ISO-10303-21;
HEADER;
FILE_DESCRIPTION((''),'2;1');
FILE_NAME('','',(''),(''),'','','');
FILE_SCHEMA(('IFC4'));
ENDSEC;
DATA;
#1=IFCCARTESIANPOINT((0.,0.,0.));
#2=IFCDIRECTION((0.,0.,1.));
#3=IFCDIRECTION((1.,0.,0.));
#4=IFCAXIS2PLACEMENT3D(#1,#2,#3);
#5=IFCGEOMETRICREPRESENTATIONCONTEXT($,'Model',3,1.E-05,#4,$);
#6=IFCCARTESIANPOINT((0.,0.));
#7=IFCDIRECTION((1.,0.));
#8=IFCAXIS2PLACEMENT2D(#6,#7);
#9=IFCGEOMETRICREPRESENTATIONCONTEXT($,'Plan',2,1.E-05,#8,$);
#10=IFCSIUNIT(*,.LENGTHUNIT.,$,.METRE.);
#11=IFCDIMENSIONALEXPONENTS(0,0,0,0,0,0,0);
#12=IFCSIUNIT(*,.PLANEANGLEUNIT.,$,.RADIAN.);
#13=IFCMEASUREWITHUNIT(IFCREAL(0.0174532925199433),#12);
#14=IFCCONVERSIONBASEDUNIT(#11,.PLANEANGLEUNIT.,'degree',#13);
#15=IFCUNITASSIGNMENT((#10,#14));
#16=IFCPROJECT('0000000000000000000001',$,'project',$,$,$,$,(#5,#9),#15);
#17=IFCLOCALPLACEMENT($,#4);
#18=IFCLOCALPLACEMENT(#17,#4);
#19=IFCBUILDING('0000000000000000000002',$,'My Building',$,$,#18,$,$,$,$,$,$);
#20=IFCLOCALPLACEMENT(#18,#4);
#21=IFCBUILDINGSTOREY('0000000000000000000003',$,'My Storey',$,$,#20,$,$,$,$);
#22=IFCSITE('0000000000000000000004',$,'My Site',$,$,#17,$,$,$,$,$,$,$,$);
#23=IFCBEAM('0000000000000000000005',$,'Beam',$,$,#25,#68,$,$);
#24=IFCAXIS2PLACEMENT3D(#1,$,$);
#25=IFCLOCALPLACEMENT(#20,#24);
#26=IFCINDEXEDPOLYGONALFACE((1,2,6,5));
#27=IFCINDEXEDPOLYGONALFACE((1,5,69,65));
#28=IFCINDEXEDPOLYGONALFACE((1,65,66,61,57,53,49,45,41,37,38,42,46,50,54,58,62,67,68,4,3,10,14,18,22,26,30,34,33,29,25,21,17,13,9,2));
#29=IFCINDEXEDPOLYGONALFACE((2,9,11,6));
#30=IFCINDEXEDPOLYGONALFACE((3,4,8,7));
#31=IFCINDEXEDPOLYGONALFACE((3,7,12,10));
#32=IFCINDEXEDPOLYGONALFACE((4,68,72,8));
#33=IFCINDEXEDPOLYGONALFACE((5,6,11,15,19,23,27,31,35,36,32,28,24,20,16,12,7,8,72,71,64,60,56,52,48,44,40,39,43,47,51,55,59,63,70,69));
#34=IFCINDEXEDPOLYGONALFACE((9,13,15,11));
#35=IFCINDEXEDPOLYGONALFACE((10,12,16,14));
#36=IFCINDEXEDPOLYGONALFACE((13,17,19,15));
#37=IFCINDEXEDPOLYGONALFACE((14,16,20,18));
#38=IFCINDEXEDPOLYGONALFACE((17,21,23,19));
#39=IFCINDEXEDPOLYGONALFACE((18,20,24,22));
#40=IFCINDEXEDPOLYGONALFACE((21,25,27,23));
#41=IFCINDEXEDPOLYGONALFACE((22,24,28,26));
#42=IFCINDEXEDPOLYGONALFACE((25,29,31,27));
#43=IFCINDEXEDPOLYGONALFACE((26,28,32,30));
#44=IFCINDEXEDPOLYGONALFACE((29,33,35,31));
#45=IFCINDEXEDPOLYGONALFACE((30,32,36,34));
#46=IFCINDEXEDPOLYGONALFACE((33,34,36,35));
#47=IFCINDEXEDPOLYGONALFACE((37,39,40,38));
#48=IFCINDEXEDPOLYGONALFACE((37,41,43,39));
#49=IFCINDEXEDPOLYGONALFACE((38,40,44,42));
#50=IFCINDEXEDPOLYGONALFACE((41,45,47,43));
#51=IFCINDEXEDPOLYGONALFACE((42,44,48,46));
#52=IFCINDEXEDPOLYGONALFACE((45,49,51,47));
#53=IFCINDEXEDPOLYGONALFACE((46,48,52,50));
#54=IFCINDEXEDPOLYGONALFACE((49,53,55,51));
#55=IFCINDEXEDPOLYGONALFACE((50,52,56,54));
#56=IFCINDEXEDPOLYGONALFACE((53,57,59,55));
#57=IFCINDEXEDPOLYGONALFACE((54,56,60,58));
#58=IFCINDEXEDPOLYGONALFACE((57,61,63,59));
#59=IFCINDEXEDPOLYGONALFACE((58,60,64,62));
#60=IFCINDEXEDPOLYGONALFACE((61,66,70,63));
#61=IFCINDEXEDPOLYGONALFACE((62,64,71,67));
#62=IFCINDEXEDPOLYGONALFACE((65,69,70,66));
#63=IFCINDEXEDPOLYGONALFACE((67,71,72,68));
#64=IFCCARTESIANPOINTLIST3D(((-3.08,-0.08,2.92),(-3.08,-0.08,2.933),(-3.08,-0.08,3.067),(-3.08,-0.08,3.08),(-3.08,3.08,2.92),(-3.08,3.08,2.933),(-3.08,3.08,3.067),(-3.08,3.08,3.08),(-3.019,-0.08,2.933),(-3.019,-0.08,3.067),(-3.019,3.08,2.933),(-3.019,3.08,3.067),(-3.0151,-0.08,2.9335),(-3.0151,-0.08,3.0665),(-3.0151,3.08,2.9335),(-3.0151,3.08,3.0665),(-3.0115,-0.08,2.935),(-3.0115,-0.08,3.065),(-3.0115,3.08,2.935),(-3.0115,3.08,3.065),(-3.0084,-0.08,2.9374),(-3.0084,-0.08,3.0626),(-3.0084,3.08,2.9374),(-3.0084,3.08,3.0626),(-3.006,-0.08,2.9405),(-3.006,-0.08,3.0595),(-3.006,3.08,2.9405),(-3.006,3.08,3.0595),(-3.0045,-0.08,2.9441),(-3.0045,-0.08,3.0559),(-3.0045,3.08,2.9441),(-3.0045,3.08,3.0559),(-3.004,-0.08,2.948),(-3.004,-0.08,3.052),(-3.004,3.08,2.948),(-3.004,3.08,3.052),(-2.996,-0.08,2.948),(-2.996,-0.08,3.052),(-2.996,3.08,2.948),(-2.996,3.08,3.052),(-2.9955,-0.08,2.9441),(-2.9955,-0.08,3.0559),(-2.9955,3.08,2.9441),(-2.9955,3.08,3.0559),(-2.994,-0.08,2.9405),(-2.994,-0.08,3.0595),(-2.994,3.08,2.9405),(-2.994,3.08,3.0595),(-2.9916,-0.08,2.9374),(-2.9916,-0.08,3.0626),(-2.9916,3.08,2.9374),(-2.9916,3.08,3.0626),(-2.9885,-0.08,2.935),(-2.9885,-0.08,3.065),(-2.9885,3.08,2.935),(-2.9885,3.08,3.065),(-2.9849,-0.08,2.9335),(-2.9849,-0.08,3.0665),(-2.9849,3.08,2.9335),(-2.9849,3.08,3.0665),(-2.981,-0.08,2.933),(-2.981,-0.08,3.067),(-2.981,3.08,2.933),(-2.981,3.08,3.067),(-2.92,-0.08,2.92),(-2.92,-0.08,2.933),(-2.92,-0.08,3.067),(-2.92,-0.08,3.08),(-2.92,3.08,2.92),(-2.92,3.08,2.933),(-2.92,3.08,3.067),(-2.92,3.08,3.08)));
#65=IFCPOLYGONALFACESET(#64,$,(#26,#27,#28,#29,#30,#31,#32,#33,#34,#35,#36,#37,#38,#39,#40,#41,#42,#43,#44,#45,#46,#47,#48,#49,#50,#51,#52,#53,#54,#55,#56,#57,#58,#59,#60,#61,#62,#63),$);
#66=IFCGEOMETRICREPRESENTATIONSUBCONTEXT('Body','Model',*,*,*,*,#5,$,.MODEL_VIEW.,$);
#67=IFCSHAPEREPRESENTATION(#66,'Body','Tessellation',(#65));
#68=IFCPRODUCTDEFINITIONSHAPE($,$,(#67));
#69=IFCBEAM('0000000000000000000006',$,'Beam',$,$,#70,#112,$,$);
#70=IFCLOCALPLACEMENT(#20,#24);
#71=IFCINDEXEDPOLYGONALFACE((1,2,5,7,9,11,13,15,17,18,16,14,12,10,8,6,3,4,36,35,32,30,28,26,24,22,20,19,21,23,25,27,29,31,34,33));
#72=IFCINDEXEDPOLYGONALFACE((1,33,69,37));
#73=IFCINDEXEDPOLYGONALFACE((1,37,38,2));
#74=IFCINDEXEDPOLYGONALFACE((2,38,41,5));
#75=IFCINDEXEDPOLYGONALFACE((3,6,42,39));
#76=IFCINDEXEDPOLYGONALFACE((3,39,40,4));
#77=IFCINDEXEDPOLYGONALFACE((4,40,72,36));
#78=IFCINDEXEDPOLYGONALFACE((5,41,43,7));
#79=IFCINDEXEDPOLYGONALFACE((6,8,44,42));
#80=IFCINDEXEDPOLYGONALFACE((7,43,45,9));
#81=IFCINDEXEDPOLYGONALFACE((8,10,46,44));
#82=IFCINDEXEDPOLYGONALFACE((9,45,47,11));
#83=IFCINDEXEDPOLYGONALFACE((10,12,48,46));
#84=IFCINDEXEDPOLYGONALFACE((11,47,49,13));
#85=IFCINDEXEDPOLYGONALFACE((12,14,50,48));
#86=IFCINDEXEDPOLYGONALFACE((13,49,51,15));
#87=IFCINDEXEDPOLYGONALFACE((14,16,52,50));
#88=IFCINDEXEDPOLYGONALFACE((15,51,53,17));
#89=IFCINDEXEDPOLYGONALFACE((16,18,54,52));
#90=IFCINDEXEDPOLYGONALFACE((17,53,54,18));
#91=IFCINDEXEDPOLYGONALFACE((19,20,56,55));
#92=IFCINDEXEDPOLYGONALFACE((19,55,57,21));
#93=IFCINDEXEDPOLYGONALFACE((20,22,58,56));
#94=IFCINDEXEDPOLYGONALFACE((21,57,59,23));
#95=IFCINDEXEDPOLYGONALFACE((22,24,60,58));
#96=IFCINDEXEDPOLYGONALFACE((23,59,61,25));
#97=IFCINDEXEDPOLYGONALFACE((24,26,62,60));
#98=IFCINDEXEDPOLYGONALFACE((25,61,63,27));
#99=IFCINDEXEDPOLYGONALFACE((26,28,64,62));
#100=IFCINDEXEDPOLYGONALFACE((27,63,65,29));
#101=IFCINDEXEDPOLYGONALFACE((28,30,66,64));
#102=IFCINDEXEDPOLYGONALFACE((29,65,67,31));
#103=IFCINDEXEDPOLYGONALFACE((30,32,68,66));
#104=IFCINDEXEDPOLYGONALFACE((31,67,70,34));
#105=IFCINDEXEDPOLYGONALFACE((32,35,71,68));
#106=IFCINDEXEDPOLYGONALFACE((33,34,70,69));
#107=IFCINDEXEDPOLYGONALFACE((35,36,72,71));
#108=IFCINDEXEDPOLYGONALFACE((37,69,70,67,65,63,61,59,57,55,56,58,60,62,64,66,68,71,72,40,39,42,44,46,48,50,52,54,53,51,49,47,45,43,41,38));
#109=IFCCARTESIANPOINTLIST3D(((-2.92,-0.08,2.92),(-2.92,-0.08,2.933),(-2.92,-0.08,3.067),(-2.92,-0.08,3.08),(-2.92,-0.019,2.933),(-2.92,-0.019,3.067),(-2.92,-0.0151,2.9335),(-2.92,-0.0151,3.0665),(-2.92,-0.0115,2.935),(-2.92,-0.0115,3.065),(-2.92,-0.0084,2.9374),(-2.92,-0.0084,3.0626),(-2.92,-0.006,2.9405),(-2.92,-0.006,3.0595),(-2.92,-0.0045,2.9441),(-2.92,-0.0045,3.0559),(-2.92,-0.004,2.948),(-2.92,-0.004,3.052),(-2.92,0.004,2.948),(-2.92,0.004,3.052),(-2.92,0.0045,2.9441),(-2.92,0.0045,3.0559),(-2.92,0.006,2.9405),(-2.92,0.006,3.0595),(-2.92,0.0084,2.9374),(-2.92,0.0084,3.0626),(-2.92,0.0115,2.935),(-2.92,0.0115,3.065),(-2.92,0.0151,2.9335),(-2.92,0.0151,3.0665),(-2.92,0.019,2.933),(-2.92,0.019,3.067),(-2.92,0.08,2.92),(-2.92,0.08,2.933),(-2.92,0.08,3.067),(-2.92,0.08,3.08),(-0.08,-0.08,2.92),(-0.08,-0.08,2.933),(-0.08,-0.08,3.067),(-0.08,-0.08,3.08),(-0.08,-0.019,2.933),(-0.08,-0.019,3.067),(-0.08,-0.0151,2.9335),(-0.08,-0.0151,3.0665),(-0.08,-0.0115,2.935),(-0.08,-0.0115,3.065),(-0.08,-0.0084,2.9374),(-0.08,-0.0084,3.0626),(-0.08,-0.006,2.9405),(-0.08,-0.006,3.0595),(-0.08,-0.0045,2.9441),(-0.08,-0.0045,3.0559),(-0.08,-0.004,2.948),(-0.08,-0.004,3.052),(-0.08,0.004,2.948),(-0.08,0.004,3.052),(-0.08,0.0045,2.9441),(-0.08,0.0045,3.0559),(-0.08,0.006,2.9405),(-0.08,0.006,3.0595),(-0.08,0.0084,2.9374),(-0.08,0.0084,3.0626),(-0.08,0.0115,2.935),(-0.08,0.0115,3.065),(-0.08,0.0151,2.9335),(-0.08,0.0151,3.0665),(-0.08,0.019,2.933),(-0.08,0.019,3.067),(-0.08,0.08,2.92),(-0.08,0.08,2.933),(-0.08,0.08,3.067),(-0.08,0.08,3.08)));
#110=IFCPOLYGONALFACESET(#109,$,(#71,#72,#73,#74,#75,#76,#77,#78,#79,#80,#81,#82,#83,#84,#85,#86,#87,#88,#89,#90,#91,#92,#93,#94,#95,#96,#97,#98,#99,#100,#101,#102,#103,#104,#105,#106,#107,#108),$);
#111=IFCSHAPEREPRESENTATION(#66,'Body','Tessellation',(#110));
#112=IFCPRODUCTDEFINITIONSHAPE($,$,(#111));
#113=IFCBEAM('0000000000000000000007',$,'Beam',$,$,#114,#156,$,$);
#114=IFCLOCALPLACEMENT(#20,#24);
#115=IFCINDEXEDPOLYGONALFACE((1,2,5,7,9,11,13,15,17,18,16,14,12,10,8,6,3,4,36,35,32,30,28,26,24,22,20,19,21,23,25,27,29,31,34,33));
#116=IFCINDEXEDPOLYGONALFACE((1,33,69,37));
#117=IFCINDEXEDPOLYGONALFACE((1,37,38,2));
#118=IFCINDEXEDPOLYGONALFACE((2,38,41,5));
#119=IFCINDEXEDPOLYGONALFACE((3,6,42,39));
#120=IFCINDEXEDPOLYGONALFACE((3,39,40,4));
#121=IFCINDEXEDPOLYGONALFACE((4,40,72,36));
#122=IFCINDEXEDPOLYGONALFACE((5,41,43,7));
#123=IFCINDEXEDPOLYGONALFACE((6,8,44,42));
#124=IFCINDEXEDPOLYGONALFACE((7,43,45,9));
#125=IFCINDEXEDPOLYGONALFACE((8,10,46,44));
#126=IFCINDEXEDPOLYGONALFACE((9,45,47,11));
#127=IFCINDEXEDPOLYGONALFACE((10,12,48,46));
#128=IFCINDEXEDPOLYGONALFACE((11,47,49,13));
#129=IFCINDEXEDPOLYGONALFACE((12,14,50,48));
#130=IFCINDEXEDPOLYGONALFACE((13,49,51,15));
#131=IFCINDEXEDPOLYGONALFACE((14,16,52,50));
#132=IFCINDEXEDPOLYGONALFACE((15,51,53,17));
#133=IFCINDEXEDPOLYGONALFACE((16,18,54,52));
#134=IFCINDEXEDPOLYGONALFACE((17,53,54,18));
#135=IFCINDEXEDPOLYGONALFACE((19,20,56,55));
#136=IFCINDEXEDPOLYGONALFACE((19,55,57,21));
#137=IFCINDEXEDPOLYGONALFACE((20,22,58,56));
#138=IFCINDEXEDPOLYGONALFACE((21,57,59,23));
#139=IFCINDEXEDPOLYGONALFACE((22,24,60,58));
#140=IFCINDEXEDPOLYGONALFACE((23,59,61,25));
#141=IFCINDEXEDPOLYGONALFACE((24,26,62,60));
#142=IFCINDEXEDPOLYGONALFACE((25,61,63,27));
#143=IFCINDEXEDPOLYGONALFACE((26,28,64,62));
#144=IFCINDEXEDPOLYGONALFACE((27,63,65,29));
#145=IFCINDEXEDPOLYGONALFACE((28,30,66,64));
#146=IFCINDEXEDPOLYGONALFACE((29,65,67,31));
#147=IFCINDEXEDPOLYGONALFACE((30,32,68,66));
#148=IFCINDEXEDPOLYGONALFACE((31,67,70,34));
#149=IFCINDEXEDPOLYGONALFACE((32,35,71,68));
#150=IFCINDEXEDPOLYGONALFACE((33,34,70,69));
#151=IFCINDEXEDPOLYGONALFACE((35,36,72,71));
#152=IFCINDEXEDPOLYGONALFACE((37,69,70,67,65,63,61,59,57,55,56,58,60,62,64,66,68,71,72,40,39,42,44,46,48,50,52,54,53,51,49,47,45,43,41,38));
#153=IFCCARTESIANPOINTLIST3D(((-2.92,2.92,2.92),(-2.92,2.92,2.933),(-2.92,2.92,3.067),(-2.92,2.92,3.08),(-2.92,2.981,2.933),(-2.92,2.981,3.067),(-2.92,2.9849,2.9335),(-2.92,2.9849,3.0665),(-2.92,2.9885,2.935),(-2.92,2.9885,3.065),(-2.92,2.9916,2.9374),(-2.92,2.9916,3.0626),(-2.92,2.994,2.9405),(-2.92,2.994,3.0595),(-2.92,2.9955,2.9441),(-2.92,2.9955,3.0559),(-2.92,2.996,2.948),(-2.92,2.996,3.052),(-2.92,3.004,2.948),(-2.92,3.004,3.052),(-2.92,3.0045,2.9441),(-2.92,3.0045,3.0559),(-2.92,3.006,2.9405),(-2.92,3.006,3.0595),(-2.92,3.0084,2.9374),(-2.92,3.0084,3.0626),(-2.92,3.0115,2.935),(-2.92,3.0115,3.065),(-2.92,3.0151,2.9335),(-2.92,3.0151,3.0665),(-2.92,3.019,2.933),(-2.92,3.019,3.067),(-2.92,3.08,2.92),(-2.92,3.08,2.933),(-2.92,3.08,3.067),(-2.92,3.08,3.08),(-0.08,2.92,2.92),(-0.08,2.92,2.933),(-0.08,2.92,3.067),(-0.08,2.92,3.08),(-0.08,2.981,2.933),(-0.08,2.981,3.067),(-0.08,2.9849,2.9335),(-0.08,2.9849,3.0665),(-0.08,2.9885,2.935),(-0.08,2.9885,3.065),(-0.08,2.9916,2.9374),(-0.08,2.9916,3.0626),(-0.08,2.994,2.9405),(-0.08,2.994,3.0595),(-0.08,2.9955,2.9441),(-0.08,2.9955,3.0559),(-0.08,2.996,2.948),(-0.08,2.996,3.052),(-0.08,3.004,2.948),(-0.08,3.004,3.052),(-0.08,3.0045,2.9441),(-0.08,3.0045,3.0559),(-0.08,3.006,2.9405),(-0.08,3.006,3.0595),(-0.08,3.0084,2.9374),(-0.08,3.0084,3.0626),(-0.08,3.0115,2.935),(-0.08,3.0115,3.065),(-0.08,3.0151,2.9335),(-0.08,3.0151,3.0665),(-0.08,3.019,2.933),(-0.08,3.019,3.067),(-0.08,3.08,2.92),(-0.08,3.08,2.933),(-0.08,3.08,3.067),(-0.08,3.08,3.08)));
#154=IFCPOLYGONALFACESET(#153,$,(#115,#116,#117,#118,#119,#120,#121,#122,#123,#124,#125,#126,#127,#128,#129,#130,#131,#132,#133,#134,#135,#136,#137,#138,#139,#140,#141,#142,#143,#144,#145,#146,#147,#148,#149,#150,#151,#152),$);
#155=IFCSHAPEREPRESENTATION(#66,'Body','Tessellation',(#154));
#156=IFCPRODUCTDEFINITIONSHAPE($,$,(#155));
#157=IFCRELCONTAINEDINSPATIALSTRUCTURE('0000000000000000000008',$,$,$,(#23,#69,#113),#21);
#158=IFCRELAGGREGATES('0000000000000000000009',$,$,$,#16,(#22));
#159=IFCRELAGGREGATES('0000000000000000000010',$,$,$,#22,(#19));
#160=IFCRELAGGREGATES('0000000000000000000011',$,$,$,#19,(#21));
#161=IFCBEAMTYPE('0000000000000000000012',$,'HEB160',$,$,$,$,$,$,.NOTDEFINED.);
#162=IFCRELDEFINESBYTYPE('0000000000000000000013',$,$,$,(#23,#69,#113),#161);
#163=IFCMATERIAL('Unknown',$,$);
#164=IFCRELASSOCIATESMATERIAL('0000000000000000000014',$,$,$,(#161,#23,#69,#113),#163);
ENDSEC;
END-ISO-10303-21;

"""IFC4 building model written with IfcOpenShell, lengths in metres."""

from ifc_helpers import new_model, entity, si_unit, converted_unit, frame, origin_with_axes, origin_2d_with_axis, place, context, subcontext, project, spatial, i_section, extrude, material, material_profile, profile_set, profile_usage, type_object, element, save


model = new_model("IFC4")

# Units and contexts
model_context = context("Model", 3, precision=1e-05, world=origin_with_axes())
plan_context = context("Plan", 2, precision=1e-05, world=origin_2d_with_axis())
body_context = subcontext(model_context, "Body", "Model", "MODEL_VIEW")
ifc_project = project(units=[si_unit("LENGTHUNIT", "METRE"), converted_unit("PLANEANGLEUNIT", "degree", entity("IfcReal", 0.0174532925199433), si_unit("PLANEANGLEUNIT", "RADIAN"), dimensions=[0, 0, 0, 0, 0, 0, 0])], contexts=[model_context, plan_context])

# Site, building, storey
site_placement = place(None, origin_with_axes())
site = spatial("IfcSite", under=ifc_project, at=site_placement, Name="My Site")
building_placement = place(site_placement, origin_with_axes())
building = spatial("IfcBuilding", under=site, at=building_placement, Name="My Building")
storey_placement = place(building_placement, origin_with_axes())
storey = spatial("IfcBuildingStorey", under=building, at=storey_placement, Name="My Storey")

# Shared definitions
ifc_material = material(Name="Unknown")

# Beams
ifc_material_profile_1 = material_profile(ifc_material, i_section(OverallWidth=0.16, OverallDepth=0.16, WebThickness=0.008, FlangeThickness=0.013, FilletRadius=0.015))
ifc_profile_set_1 = profile_set([ifc_material_profile_1])
beam_type = type_object("IfcBeamType", Name="HEB160", PredefinedType="NOTDEFINED", material=ifc_profile_set_1)
ifc_profile_usage_1 = profile_usage(ifc_profile_set_1, cardinal=5)
beam_1_placement = place(storey_placement, frame((-3.0, -0.08, 3.0), z_axis=(0.0, 1.0, 0.0), x_axis=(-1.0, 0.0, 0.0)))
element("IfcBeam", 1, at=beam_1_placement, inside=storey, type_object=beam_type, material=ifc_profile_usage_1, Name="Beam", context=body_context, shape_type="SweptSolid", body=[
    extrude(i_section(OverallWidth=0.16, OverallDepth=0.16, WebThickness=0.008, FlangeThickness=0.013, FilletRadius=0.015), origin_with_axes(), (0.0, 0.0, 1.0), 3.16),
])
ifc_profile_usage_2 = profile_usage(ifc_profile_set_1, cardinal=5)
beam_2_placement = place(storey_placement, frame((-2.92, 0.0, 3.0), z_axis=(1.0, 0.0, 0.0), x_axis=(0.0, 1.0, 0.0)))
element("IfcBeam", 2, at=beam_2_placement, inside=storey, type_object=beam_type, material=ifc_profile_usage_2, Name="Beam", context=body_context, shape_type="SweptSolid", body=[
    extrude(i_section(OverallWidth=0.16, OverallDepth=0.16, WebThickness=0.008, FlangeThickness=0.013, FilletRadius=0.015), origin_with_axes(), (0.0, 0.0, 1.0), 2.84),
])
ifc_profile_usage_3 = profile_usage(ifc_profile_set_1, cardinal=5)
beam_3_placement = place(storey_placement, frame((-2.92, 3.0, 3.0), z_axis=(1.0, 0.0, 0.0), x_axis=(0.0, 1.0, 0.0)))
element("IfcBeam", 3, at=beam_3_placement, inside=storey, type_object=beam_type, material=ifc_profile_usage_3, Name="Beam", context=body_context, shape_type="SweptSolid", body=[
    extrude(i_section(OverallWidth=0.16, OverallDepth=0.16, WebThickness=0.008, FlangeThickness=0.013, FilletRadius=0.015), origin_with_axes(), (0.0, 0.0, 1.0), 2.84),
])

save(model, "model.ifc")
